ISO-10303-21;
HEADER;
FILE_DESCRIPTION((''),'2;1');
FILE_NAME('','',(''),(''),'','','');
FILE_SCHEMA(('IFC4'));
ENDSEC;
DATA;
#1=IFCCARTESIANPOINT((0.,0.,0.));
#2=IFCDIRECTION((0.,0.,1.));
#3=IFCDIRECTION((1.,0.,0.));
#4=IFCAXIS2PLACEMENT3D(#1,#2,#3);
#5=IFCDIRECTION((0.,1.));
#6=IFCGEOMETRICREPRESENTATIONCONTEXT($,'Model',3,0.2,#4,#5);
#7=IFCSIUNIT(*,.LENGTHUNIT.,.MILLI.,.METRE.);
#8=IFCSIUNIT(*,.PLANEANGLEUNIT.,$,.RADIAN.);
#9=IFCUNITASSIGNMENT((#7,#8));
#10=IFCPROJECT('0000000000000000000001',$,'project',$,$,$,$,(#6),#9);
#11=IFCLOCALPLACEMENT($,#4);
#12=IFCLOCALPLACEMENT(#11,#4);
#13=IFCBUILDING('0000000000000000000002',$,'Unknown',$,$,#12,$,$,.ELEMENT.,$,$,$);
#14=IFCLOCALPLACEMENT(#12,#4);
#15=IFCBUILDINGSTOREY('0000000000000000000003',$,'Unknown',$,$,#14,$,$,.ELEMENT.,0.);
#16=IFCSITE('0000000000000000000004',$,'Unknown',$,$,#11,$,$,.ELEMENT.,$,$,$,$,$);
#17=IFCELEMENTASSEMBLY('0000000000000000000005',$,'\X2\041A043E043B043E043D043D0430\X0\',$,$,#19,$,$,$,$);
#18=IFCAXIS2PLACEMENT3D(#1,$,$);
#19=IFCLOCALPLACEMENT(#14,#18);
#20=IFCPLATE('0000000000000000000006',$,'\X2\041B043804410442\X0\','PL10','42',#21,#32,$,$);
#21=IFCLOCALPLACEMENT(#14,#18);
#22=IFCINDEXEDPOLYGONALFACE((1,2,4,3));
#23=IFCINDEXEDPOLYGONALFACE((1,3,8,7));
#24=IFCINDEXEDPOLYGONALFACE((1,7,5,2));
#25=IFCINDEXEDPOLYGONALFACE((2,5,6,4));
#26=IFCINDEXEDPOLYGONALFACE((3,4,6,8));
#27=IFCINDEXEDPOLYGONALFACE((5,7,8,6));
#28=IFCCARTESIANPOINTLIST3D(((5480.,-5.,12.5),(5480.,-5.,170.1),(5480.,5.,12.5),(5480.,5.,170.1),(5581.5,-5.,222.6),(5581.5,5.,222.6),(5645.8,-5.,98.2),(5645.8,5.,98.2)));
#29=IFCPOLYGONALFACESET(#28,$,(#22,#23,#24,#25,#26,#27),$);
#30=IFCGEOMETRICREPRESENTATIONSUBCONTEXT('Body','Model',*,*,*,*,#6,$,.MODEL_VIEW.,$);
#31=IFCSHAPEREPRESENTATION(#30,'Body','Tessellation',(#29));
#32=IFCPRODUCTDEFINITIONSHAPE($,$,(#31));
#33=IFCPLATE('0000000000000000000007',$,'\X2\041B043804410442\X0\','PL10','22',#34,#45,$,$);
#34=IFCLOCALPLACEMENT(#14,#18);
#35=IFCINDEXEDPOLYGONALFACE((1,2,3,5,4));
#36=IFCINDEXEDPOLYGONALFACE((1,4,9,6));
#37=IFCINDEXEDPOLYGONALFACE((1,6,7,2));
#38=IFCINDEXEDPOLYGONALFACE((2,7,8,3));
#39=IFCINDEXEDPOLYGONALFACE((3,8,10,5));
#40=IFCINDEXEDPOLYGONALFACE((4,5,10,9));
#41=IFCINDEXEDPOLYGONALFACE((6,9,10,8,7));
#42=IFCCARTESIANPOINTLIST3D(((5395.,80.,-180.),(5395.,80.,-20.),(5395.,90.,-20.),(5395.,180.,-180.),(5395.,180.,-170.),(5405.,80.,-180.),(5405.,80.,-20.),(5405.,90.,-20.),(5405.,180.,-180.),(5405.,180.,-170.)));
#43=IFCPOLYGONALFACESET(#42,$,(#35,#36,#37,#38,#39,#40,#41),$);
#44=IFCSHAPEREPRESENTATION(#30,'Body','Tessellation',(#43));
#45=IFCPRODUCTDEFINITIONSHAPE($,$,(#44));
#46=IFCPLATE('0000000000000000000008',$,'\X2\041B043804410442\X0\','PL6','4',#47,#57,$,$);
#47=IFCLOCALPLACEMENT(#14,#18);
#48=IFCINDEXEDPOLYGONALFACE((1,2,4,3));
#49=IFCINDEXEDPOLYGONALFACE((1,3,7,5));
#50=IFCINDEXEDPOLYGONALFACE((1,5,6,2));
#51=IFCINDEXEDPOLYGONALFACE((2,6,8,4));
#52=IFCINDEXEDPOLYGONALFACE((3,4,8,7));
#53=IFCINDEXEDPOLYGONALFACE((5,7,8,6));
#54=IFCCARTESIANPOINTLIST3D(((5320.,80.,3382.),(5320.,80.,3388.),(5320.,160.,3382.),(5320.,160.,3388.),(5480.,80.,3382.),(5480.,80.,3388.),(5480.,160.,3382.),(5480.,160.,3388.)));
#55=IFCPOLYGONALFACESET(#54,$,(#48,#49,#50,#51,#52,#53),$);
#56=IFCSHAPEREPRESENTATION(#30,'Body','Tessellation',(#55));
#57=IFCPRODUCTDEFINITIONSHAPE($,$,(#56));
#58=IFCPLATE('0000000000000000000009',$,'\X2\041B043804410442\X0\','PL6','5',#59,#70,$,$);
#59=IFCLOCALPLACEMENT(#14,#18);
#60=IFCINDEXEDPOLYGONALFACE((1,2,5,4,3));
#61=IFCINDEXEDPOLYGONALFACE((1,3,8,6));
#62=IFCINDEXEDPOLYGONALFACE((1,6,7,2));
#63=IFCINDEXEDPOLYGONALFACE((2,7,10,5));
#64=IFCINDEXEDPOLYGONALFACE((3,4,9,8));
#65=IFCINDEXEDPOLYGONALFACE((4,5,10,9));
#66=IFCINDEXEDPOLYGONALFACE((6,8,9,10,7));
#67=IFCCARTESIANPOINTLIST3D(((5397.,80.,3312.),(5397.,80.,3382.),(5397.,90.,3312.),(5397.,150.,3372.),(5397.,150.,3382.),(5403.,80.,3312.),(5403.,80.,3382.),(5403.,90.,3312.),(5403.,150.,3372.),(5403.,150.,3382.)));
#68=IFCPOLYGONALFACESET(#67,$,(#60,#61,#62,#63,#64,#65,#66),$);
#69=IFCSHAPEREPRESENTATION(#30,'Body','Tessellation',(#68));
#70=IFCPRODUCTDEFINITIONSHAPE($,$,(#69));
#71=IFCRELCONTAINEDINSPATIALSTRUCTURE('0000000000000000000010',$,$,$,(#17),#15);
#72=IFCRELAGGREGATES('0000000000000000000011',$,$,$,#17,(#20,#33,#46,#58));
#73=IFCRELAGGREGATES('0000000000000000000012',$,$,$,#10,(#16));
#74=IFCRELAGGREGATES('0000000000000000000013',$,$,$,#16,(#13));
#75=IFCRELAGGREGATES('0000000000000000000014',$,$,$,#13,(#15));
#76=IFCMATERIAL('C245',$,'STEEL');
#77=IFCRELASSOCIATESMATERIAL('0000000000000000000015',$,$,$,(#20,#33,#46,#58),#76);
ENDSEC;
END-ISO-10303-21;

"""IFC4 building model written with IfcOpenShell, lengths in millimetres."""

from ifc_helpers import new_model, si_unit, direction, frame, origin_with_axes, place, context, subcontext, project, spatial, line, indexed_curve, outline, extrude, material, element, aggregate, save


model = new_model("IFC4")

# Units and contexts
model_context = context("Model", 3, precision=0.2, world=origin_with_axes(), true_north=direction((0.0, 1.0)))
body_context = subcontext(model_context, "Body", "Model", "MODEL_VIEW")
ifc_project = project(units=[si_unit("LENGTHUNIT", "METRE", prefix="MILLI"), si_unit("PLANEANGLEUNIT", "RADIAN")], contexts=[model_context])

# Site, building, storey
site_placement = place(None, origin_with_axes())
site = spatial("IfcSite", under=ifc_project, at=site_placement, Name="Unknown", CompositionType="ELEMENT")
building_placement = place(site_placement, origin_with_axes())
building = spatial("IfcBuilding", under=site, at=building_placement, Name="Unknown", CompositionType="ELEMENT")
storey_placement = place(building_placement, origin_with_axes())
storey = spatial("IfcBuildingStorey", under=building, at=storey_placement, Name="Unknown", CompositionType="ELEMENT", Elevation=0.0)

# Shared definitions
ifc_material_1 = material(Name="C245", Category="STEEL")

# Element assembly, plates
assembly_1_placement = place(storey_placement, frame((5400.0, 0.0, -40.0), z_axis=(-1.0, 0.0, 0.0), x_axis=(0.0, 0.0, 1.0)))
assembly_1 = element("IfcElementAssembly", 1, at=assembly_1_placement, inside=storey, Name="Колонна")
plate_1_placement = place(assembly_1_placement, frame((52.5, 0.0, -80.0), z_axis=(0.0, -1.0, 0.0), x_axis=(0.45902, 0.0, -0.888426)))
plate_1 = element("IfcPlate", 2, at=plate_1_placement, material=ifc_material_1, Name="Лист", Description="PL10", ObjectType="42", context=body_context, shape_type="SolidModel", body=[
    extrude(outline(indexed_curve([(0.0, 0.0), (186.6, 0.0), (186.6, 140.0), (72.3, 140.0)], segments=[line(1, 2, 3, 4, 1)])), frame((0.0, 0.0, 5.0), z_axis=(0.0, 0.0, 1.0), x_axis=(1.0, 0.0, 0.0)), (0.0, 0.0, -1.0), 10.0),
])
plate_2_placement = place(assembly_1_placement, frame((-140.0, 180.0, 0.0), z_axis=(0.0, 0.0, 1.0), x_axis=(0.0, -1.0, 0.0)))
plate_2 = element("IfcPlate", 3, at=plate_2_placement, material=ifc_material_1, Name="Лист", Description="PL10", ObjectType="22", context=body_context, shape_type="SolidModel", body=[
    extrude(outline(indexed_curve([(0.0, 0.0), (100.0, 0.0), (100.0, 160.0), (90.0, 160.0), (0.0, 10.0)], segments=[line(1, 2, 3, 4, 5, 1)])), frame((0.0, 0.0, 5.0), z_axis=(0.0, 0.0, 1.0), x_axis=(1.0, 0.0, 0.0)), (0.0, 0.0, -1.0), 10.0),
])
plate_3_placement = place(assembly_1_placement, frame((3425.0, 80.0, -80.0), z_axis=(-1.0, 0.0, 0.0), x_axis=(0.0, 0.0, 1.0)))
plate_3 = element("IfcPlate", 4, at=plate_3_placement, material=ifc_material_1, Name="Лист", Description="PL6", ObjectType="4", context=body_context, shape_type="SolidModel", body=[
    extrude(outline(indexed_curve([(0.0, 0.0), (160.0, 0.0), (160.0, 80.0), (0.0, 80.0)], segments=[line(1, 2, 3, 4, 1)])), frame((0.0, 0.0, 3.0), z_axis=(0.0, 0.0, 1.0), x_axis=(1.0, 0.0, 0.0)), (0.0, 0.0, -1.0), 6.0),
])
plate_4_placement = place(assembly_1_placement, frame((3422.0, 150.0, 0.0), z_axis=(0.0, 0.0, -1.0), x_axis=(0.0, -1.0, 0.0)))
plate_4 = element("IfcPlate", 5, at=plate_4_placement, material=ifc_material_1, Name="Лист", Description="PL6", ObjectType="5", context=body_context, shape_type="SolidModel", body=[
    extrude(outline(indexed_curve([(0.0, 0.0), (70.0, 0.0), (70.0, 70.0), (60.0, 70.0), (0.0, 10.0)], segments=[line(1, 2, 3, 4, 5, 1)])), frame((0.0, 0.0, 3.0), z_axis=(0.0, 0.0, 1.0), x_axis=(1.0, 0.0, 0.0)), (0.0, 0.0, -1.0), 6.0),
])

aggregate(assembly_1, [plate_1, plate_2, plate_3, plate_4])

save(model, "model.ifc")
